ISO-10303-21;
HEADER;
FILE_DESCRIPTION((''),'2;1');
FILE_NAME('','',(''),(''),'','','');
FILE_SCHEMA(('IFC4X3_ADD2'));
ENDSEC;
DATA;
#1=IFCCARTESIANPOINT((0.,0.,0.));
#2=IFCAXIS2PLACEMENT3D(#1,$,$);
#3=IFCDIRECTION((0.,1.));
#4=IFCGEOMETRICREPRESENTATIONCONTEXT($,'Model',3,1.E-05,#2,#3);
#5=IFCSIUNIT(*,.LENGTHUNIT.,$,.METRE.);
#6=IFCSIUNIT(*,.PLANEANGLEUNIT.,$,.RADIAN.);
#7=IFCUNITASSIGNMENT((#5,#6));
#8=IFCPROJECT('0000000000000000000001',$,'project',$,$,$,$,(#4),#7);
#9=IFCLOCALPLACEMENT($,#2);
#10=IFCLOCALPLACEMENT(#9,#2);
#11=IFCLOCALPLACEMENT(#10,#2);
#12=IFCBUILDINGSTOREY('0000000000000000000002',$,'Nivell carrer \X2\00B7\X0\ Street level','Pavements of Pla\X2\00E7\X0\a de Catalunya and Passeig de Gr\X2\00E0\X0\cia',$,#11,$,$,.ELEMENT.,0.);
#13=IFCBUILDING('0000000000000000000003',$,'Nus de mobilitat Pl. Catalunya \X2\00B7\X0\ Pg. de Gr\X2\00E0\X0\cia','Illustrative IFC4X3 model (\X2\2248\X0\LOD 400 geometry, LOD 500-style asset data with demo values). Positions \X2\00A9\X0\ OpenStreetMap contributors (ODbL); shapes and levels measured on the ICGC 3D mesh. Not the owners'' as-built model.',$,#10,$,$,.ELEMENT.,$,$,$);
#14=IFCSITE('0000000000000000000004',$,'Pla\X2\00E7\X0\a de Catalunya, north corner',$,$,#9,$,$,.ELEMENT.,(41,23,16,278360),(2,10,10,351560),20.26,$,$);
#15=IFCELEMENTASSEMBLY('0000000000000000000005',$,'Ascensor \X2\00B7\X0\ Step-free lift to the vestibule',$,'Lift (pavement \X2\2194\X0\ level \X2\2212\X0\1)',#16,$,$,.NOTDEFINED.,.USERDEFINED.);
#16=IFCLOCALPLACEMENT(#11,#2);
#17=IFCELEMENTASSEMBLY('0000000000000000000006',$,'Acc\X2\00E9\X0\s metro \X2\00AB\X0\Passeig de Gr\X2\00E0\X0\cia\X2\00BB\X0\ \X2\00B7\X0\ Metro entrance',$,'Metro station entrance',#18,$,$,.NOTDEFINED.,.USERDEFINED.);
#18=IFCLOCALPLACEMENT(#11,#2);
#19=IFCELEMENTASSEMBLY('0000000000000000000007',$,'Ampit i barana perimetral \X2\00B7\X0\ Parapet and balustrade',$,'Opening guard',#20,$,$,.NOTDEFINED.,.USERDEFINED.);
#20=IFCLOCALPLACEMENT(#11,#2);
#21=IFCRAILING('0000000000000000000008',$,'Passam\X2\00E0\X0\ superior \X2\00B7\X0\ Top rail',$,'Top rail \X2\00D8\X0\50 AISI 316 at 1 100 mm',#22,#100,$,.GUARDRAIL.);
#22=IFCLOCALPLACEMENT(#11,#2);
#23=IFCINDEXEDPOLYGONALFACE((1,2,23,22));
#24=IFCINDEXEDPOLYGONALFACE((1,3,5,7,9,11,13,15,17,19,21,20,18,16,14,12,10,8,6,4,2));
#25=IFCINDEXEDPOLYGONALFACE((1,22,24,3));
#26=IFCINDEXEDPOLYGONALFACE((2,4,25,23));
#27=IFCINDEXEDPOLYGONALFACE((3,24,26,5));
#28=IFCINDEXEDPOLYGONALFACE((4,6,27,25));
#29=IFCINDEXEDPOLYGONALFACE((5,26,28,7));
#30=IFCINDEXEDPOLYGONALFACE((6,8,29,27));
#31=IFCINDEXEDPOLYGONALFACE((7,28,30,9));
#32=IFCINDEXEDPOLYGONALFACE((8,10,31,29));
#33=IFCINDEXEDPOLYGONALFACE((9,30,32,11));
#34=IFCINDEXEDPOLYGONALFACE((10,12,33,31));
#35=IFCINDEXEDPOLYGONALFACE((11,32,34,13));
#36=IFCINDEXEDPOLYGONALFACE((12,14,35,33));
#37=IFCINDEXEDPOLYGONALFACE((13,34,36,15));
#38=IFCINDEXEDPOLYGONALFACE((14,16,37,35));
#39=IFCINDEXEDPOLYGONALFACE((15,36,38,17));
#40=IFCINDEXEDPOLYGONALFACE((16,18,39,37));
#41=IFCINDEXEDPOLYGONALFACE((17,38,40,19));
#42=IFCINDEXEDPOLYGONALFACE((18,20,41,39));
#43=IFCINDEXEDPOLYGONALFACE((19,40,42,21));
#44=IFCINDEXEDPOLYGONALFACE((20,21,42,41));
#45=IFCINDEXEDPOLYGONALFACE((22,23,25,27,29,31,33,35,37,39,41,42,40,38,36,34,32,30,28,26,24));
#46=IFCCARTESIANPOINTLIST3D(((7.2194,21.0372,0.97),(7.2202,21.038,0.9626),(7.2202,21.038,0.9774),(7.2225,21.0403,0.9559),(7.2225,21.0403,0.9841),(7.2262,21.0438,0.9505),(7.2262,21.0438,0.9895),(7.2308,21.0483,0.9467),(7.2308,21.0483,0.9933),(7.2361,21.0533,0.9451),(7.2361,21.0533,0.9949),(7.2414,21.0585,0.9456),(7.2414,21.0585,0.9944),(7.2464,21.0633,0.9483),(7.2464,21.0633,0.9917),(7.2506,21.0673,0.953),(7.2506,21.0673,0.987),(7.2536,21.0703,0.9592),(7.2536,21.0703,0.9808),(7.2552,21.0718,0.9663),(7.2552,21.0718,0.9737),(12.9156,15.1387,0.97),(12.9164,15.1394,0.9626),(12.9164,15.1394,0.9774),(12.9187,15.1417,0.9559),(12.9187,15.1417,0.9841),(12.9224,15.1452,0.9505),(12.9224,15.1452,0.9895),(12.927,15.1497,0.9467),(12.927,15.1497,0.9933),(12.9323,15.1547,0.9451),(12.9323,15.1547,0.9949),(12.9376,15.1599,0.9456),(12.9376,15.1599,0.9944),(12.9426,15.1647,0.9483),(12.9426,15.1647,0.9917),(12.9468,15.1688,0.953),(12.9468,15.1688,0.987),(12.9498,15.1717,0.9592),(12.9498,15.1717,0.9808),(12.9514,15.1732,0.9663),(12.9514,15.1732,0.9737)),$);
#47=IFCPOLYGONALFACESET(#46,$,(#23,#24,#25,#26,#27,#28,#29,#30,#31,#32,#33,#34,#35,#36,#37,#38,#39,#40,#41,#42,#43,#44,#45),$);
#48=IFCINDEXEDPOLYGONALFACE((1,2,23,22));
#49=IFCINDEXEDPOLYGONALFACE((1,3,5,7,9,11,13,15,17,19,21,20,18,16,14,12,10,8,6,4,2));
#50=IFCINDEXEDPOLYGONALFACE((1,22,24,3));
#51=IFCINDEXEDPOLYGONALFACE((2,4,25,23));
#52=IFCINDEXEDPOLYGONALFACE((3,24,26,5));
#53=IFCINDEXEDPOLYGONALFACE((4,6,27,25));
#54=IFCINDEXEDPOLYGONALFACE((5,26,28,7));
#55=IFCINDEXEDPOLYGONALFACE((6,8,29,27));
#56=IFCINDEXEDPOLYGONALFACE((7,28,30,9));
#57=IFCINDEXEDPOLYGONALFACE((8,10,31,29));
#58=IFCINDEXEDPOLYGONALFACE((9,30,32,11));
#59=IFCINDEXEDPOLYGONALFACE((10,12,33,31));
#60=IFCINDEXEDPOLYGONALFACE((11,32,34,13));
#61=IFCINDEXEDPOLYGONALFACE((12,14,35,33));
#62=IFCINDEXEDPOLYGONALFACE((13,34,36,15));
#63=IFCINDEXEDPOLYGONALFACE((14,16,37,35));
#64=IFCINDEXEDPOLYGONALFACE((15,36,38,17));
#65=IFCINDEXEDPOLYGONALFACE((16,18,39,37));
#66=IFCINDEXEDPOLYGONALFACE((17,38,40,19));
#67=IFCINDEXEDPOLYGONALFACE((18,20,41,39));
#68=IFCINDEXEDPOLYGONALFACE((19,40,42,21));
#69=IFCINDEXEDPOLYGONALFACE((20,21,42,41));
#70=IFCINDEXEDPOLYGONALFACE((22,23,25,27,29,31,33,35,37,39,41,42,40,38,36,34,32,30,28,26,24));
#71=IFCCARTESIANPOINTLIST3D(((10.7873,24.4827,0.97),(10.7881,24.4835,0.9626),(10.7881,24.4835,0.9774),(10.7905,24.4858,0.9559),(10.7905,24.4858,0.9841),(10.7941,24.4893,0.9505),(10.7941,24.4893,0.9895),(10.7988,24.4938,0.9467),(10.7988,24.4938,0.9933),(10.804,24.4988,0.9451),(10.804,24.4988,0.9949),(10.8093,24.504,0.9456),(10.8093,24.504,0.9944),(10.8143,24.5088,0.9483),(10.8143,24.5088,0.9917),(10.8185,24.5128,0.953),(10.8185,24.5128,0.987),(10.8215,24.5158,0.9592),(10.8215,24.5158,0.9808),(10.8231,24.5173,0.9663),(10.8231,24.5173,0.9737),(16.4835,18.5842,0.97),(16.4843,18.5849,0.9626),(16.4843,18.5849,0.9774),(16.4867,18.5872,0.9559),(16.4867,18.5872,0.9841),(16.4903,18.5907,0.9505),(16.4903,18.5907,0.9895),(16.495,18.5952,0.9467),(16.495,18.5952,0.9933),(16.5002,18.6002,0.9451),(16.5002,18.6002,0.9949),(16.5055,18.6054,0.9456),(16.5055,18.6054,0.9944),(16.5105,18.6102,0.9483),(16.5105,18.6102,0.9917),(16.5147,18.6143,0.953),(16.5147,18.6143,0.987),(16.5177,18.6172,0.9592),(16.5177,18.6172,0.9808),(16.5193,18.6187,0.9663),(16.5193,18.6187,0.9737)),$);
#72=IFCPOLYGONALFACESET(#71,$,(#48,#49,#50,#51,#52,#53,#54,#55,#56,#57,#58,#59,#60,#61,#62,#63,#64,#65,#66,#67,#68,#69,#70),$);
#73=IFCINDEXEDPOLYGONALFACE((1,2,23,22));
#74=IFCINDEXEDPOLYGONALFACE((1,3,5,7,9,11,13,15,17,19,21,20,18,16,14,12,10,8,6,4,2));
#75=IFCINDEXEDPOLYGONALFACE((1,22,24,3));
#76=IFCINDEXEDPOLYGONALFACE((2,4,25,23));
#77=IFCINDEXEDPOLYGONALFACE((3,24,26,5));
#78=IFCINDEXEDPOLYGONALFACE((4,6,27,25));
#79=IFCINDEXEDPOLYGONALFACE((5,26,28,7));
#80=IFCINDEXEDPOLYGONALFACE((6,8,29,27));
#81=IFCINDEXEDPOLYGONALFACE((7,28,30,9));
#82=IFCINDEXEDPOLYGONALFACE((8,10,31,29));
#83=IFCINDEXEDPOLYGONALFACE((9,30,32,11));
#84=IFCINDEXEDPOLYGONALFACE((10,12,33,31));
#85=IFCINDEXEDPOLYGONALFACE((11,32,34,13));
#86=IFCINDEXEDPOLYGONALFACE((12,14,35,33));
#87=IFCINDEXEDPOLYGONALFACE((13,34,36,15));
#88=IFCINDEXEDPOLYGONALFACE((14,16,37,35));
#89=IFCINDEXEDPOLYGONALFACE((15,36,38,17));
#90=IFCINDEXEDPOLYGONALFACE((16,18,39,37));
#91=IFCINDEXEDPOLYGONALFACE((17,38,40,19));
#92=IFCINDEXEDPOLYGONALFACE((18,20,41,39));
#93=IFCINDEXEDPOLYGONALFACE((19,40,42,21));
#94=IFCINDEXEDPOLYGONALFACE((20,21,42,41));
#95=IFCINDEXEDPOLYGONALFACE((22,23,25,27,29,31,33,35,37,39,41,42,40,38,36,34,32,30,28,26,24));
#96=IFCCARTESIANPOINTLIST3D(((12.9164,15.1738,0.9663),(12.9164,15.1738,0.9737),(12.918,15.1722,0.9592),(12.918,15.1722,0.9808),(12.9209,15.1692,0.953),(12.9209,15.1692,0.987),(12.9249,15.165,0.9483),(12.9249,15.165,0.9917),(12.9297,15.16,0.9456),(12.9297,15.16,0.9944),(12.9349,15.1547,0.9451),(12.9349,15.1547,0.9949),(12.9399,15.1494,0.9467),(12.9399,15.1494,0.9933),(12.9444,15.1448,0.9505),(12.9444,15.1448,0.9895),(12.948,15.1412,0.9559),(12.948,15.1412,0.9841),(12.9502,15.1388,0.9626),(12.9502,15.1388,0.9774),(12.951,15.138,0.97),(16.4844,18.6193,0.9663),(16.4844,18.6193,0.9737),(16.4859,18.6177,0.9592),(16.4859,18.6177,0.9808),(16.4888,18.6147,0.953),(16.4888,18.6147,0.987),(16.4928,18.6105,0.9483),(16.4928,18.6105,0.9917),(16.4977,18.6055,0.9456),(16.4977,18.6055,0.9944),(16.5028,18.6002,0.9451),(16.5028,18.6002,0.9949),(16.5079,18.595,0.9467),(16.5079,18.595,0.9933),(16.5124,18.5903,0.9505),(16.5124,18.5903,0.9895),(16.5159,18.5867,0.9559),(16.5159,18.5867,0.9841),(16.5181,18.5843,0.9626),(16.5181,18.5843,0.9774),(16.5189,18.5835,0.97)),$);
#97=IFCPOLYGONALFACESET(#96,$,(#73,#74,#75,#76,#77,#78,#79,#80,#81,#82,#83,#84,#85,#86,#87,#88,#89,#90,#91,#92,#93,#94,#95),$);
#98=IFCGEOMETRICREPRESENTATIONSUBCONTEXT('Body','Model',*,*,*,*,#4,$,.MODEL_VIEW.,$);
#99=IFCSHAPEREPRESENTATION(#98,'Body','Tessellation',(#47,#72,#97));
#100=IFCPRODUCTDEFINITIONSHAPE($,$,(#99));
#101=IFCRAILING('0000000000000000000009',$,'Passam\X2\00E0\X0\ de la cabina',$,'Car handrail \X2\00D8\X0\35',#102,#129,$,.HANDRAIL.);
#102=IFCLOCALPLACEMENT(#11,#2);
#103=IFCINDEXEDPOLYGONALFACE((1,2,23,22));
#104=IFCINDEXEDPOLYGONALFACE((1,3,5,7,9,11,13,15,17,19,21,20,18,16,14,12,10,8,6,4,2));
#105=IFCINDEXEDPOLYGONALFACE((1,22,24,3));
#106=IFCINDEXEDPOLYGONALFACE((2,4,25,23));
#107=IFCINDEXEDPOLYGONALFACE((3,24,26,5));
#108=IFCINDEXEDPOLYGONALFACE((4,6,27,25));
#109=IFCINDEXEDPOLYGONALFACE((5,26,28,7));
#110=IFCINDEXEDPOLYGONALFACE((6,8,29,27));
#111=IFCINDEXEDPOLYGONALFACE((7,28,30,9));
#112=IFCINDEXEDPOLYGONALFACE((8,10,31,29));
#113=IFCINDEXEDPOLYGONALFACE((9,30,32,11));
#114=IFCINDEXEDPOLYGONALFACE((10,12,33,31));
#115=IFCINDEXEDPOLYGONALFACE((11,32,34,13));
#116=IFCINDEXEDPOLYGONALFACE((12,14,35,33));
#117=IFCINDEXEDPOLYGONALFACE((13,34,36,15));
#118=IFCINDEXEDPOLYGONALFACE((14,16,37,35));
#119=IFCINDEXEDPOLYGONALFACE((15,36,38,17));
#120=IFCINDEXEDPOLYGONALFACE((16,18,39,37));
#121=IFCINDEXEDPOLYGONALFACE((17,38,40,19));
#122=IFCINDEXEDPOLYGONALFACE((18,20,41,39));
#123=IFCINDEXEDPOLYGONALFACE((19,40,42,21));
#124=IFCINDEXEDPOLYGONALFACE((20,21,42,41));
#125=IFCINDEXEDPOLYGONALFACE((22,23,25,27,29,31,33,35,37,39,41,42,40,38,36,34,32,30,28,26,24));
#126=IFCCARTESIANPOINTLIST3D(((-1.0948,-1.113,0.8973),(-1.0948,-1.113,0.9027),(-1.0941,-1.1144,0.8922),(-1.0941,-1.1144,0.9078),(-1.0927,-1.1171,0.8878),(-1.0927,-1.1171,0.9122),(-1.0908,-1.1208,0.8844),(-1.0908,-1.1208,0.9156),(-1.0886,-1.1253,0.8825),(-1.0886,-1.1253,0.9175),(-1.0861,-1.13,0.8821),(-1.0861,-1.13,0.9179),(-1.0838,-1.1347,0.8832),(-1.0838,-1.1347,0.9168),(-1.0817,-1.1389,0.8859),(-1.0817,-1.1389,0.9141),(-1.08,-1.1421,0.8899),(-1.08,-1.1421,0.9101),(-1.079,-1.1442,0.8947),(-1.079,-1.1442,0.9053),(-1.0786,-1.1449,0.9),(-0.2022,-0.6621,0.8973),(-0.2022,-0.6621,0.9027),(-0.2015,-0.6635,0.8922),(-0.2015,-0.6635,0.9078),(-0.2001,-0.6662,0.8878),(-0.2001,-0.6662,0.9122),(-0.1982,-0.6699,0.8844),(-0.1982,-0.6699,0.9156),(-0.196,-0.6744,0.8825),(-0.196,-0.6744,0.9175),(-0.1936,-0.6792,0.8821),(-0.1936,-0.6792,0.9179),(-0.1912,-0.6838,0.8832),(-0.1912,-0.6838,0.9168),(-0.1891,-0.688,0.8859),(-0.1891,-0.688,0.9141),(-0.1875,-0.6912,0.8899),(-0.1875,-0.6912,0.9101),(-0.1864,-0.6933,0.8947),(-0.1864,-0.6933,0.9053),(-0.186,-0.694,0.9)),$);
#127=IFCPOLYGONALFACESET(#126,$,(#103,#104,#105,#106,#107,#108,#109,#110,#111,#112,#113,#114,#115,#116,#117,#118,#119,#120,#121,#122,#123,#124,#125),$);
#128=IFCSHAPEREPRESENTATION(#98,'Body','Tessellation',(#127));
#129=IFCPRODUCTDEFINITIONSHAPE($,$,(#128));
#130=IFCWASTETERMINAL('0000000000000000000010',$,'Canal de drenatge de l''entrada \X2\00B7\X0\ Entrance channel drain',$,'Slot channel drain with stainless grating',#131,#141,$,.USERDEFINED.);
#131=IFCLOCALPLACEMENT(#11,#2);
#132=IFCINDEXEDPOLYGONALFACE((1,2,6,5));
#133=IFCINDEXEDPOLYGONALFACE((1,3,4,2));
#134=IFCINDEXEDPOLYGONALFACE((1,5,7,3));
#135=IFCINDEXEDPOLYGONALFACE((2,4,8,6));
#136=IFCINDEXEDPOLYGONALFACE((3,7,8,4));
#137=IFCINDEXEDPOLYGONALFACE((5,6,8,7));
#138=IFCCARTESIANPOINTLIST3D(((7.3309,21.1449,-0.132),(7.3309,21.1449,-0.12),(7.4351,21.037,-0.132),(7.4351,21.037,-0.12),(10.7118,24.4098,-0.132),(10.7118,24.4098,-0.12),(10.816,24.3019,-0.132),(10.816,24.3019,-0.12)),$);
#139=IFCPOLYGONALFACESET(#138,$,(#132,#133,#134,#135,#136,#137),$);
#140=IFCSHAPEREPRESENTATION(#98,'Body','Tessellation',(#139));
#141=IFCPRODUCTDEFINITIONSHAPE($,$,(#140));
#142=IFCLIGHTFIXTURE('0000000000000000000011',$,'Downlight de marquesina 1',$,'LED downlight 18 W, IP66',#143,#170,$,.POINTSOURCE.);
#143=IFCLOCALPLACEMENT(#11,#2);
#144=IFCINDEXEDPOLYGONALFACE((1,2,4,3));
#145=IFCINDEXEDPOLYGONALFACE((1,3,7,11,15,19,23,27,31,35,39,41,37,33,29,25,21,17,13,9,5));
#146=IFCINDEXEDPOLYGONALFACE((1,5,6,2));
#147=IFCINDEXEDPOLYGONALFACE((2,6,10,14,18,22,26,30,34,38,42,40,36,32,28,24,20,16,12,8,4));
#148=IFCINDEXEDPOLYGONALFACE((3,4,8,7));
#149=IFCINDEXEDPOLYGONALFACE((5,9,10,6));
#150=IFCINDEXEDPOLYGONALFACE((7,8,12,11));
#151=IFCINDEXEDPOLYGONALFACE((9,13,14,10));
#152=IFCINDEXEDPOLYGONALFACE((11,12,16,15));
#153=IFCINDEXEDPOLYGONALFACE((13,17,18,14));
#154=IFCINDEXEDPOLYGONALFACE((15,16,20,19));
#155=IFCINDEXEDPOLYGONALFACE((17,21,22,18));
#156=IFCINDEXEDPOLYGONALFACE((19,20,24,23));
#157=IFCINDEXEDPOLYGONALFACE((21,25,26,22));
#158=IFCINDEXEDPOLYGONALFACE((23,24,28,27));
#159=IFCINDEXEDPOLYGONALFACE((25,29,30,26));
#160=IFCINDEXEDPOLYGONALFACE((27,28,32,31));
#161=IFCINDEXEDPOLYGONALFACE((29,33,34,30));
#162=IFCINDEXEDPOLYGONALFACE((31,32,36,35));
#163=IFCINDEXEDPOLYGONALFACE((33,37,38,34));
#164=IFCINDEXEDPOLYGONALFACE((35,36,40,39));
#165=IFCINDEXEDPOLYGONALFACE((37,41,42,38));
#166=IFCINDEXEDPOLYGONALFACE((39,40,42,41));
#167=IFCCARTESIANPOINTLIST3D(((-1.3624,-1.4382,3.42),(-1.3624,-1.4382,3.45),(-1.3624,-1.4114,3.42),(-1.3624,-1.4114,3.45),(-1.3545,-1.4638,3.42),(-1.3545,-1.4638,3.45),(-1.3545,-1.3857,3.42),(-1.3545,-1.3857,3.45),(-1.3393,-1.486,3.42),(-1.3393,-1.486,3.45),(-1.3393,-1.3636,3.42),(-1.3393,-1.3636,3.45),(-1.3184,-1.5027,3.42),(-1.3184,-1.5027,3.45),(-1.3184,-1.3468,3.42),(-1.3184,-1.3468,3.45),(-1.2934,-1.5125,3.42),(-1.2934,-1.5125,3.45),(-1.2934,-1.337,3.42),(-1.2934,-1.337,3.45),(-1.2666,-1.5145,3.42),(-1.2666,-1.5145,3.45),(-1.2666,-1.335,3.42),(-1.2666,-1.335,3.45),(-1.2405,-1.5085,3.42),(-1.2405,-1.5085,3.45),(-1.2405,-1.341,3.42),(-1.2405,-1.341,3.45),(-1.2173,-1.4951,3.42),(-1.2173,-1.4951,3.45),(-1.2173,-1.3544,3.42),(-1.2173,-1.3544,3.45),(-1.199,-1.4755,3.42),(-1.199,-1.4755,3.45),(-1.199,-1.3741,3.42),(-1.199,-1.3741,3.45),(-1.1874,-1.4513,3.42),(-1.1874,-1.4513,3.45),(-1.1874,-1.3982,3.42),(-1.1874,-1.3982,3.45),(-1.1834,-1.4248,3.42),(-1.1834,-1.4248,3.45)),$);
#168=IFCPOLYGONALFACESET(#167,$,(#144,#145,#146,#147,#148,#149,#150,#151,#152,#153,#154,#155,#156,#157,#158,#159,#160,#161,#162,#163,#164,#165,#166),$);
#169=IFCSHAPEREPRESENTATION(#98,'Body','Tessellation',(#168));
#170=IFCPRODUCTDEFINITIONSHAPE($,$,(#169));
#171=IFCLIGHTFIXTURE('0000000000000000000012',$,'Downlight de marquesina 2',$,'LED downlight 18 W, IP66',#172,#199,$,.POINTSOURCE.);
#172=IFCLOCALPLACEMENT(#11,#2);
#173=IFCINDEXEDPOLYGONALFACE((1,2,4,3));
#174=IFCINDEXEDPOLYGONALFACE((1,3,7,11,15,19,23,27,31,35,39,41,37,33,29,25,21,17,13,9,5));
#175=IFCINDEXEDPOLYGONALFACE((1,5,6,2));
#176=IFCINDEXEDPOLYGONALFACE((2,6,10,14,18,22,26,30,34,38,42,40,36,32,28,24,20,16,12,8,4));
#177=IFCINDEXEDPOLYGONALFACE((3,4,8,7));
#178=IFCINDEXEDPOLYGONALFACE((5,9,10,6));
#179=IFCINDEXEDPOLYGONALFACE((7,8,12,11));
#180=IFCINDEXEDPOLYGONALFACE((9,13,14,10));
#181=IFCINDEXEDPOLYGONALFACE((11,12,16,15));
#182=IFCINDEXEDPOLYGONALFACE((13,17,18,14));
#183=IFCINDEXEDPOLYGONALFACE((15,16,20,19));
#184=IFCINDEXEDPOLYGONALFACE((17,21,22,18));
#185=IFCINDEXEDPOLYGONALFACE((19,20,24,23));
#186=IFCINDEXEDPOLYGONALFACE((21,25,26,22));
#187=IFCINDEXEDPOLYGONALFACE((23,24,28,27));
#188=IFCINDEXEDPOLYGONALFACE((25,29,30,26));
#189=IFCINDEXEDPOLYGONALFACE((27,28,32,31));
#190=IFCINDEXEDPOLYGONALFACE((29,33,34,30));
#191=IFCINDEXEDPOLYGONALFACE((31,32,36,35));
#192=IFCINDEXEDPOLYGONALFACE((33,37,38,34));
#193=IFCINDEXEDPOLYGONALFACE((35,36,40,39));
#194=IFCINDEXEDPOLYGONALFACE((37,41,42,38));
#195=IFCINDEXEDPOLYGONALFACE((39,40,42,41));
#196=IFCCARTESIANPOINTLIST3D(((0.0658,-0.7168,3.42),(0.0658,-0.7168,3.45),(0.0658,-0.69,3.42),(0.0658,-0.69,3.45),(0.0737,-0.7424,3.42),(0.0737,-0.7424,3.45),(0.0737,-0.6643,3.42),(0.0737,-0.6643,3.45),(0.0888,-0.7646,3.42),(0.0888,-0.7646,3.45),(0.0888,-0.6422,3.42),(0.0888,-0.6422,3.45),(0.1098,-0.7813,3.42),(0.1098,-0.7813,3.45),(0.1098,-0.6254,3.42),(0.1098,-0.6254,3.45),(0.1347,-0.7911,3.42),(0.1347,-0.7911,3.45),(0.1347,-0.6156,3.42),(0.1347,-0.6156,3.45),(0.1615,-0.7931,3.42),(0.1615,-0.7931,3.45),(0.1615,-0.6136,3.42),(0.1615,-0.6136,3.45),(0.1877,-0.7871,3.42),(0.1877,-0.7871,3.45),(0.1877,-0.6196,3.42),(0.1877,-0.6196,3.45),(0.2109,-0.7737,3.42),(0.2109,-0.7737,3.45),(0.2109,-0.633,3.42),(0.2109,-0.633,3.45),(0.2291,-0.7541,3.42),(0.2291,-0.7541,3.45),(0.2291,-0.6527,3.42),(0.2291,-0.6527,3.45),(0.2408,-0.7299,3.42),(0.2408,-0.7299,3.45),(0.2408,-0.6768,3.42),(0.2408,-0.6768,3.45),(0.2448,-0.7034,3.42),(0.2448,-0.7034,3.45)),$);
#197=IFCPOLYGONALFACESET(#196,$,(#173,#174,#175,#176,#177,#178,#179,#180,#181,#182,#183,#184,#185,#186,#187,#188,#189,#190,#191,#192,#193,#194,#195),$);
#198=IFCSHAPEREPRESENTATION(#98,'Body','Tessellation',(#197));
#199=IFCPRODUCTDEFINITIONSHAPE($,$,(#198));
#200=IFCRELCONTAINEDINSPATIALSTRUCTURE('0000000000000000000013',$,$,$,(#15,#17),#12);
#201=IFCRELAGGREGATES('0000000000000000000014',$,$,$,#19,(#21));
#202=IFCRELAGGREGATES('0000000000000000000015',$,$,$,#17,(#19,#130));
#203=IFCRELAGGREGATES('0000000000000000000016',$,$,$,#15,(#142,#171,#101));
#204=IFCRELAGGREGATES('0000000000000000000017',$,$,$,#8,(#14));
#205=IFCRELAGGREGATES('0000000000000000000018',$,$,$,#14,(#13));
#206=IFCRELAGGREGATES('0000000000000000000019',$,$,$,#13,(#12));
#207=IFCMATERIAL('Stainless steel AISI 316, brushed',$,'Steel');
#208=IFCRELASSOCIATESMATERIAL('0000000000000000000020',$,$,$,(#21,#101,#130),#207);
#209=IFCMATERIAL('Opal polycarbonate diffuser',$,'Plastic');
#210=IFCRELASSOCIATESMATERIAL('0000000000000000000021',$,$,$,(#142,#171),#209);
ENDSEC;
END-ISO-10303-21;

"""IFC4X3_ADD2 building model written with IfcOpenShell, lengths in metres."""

from ifc_helpers import new_model, si_unit, direction, frame, frame_2d, origin, origin_2d_with_axis, place, context, subcontext, project, spatial, rectangle, circle, extrude, material, element, aggregate, save


model = new_model("IFC4X3_ADD2")

# Units and contexts
model_context = context("Model", 3, precision=1e-05, world=origin(), true_north=direction((0.0, 1.0)))
body_context = subcontext(model_context, "Body", "Model", "MODEL_VIEW")
ifc_project = project(units=[si_unit("LENGTHUNIT", "METRE"), si_unit("PLANEANGLEUNIT", "RADIAN")], contexts=[model_context])

# Site, building, storey
site_placement = place(None, origin())
site = spatial("IfcSite", under=ifc_project, at=site_placement, Name="Plaça de Catalunya, north corner", CompositionType="ELEMENT", RefLatitude=(41, 23, 16, 278360), RefLongitude=(2, 10, 10, 351560), RefElevation=20.26)
building_placement = place(site_placement, origin())
building = spatial("IfcBuilding", under=site, at=building_placement, Name="Nus de mobilitat Pl. Catalunya · Pg. de Gràcia", Description="Illustrative IFC4X3 model (≈LOD 400 geometry, LOD 500-style asset data with demo values). Positions © OpenStreetMap contributors (ODbL); shapes and levels measured on the ICGC 3D mesh. Not the owners' as-built model.", CompositionType="ELEMENT")
storey_placement = place(building_placement, origin())
storey = spatial("IfcBuildingStorey", under=building, at=storey_placement, Name="Nivell carrer · Street level", Description="Pavements of Plaça de Catalunya and Passeig de Gràcia", CompositionType="ELEMENT", Elevation=0.0)

# Element assembly
assembly_1_placement = place(building_placement, origin())
assembly_1 = element("IfcElementAssembly", 1, at=assembly_1_placement, inside=storey, Name="Ascensor · Step-free lift to the vestibule", ObjectType="Lift (pavement ↔ level −1)", AssemblyPlace="NOTDEFINED", PredefinedType="USERDEFINED")

# Element assemblies
assembly_2_placement = place(building_placement, origin())
assembly_2 = element("IfcElementAssembly", 2, at=assembly_2_placement, inside=storey, Name="Accés metro «Passeig de Gràcia» · Metro entrance", ObjectType="Metro station entrance", AssemblyPlace="NOTDEFINED", PredefinedType="USERDEFINED")
assembly_3_placement = place(building_placement, origin())
assembly_3 = element("IfcElementAssembly", 3, at=assembly_3_placement, Name="Ampit i barana perimetral · Parapet and balustrade", ObjectType="Opening guard", AssemblyPlace="NOTDEFINED", PredefinedType="USERDEFINED")
ifc_material_1 = material(Name="Stainless steel AISI 316, brushed", Category="Steel")

# Railings
railing_1_placement = place(building_placement, origin())
railing_1 = element("IfcRailing", 4, at=railing_1_placement, material=ifc_material_1, Name="Passamà superior · Top rail", ObjectType="Top rail Ø50 AISI 316 at 1 100 mm", PredefinedType="GUARDRAIL", context=body_context, shape_type="SweptSolid", body=[
    extrude(circle(Radius=0.025, at=origin_2d_with_axis()), frame((7.2374, 21.0546, 0.97), z_axis=(0.694658, -0.71934, 0.0), x_axis=(-0.71934, -0.694658, 0.0)), (0.0, 0.0, 1.0), 8.2),
    extrude(circle(Radius=0.025, at=origin_2d_with_axis()), frame((10.8053, 24.5001, 0.97), z_axis=(0.694658, -0.71934, 0.0), x_axis=(-0.71934, -0.694658, 0.0)), (0.0, 0.0, 1.0), 8.2),
    extrude(circle(Radius=0.025, at=origin_2d_with_axis()), frame((12.9336, 15.156, 0.97), z_axis=(0.71934, 0.694658, 0.0), x_axis=(0.694658, -0.71934, 0.0)), (0.0, 0.0, 1.0), 4.96),
])
aggregate(assembly_3, [railing_1])
railing_2_placement = place(building_placement, origin())
railing_2 = element("IfcRailing", 5, at=railing_2_placement, material=ifc_material_1, Name="Passamà de la cabina", ObjectType="Car handrail Ø35", PredefinedType="HANDRAIL", context=body_context, shape_type="SweptSolid", body=[
    extrude(circle(Radius=0.018, at=origin_2d_with_axis()), frame((-1.0867, -1.1288, 0.9), z_axis=(0.892586, 0.450878, 0.0), x_axis=(0.450878, -0.892586, 0.0)), (0.0, 0.0, 1.0), 1.0),
])

# Waste terminal
waste_terminal_placement = place(building_placement, origin())
waste_terminal = element("IfcWasteTerminal", 6, at=waste_terminal_placement, material=ifc_material_1, Name="Canal de drenatge de l'entrada · Entrance channel drain", ObjectType="Slot channel drain with stainless grating", PredefinedType="USERDEFINED", context=body_context, shape_type="SweptSolid", body=[
    extrude(rectangle(XDim=0.15, YDim=4.7, at=frame_2d((0.0, 0.0), x_axis=(0.694658, -0.71934))), frame((9.0735, 22.7234, -0.132)), (0.0, 0.0, 1.0), 0.012),
])
aggregate(assembly_2, [assembly_3, waste_terminal])

# Light fixtures
ifc_material_2 = material(Name="Opal polycarbonate diffuser", Category="Plastic")
light_fixture_1_placement = place(building_placement, origin())
light_fixture_1 = element("IfcLightFixture", 7, at=light_fixture_1_placement, material=ifc_material_2, Name="Downlight de marquesina 1", ObjectType="LED downlight 18 W, IP66", PredefinedType="POINTSOURCE", context=body_context, shape_type="SweptSolid", body=[
    extrude(circle(Radius=0.09, at=origin_2d_with_axis()), frame((-1.2734, -1.4248, 3.42)), (0.0, 0.0, 1.0), 0.03),
])
light_fixture_2_placement = place(building_placement, origin())
light_fixture_2 = element("IfcLightFixture", 8, at=light_fixture_2_placement, material=ifc_material_2, Name="Downlight de marquesina 2", ObjectType="LED downlight 18 W, IP66", PredefinedType="POINTSOURCE", context=body_context, shape_type="SweptSolid", body=[
    extrude(circle(Radius=0.09, at=origin_2d_with_axis()), frame((0.1548, -0.7034, 3.42)), (0.0, 0.0, 1.0), 0.03),
])

aggregate(assembly_1, [light_fixture_1, light_fixture_2, railing_2])

save(model, "model.ifc")
